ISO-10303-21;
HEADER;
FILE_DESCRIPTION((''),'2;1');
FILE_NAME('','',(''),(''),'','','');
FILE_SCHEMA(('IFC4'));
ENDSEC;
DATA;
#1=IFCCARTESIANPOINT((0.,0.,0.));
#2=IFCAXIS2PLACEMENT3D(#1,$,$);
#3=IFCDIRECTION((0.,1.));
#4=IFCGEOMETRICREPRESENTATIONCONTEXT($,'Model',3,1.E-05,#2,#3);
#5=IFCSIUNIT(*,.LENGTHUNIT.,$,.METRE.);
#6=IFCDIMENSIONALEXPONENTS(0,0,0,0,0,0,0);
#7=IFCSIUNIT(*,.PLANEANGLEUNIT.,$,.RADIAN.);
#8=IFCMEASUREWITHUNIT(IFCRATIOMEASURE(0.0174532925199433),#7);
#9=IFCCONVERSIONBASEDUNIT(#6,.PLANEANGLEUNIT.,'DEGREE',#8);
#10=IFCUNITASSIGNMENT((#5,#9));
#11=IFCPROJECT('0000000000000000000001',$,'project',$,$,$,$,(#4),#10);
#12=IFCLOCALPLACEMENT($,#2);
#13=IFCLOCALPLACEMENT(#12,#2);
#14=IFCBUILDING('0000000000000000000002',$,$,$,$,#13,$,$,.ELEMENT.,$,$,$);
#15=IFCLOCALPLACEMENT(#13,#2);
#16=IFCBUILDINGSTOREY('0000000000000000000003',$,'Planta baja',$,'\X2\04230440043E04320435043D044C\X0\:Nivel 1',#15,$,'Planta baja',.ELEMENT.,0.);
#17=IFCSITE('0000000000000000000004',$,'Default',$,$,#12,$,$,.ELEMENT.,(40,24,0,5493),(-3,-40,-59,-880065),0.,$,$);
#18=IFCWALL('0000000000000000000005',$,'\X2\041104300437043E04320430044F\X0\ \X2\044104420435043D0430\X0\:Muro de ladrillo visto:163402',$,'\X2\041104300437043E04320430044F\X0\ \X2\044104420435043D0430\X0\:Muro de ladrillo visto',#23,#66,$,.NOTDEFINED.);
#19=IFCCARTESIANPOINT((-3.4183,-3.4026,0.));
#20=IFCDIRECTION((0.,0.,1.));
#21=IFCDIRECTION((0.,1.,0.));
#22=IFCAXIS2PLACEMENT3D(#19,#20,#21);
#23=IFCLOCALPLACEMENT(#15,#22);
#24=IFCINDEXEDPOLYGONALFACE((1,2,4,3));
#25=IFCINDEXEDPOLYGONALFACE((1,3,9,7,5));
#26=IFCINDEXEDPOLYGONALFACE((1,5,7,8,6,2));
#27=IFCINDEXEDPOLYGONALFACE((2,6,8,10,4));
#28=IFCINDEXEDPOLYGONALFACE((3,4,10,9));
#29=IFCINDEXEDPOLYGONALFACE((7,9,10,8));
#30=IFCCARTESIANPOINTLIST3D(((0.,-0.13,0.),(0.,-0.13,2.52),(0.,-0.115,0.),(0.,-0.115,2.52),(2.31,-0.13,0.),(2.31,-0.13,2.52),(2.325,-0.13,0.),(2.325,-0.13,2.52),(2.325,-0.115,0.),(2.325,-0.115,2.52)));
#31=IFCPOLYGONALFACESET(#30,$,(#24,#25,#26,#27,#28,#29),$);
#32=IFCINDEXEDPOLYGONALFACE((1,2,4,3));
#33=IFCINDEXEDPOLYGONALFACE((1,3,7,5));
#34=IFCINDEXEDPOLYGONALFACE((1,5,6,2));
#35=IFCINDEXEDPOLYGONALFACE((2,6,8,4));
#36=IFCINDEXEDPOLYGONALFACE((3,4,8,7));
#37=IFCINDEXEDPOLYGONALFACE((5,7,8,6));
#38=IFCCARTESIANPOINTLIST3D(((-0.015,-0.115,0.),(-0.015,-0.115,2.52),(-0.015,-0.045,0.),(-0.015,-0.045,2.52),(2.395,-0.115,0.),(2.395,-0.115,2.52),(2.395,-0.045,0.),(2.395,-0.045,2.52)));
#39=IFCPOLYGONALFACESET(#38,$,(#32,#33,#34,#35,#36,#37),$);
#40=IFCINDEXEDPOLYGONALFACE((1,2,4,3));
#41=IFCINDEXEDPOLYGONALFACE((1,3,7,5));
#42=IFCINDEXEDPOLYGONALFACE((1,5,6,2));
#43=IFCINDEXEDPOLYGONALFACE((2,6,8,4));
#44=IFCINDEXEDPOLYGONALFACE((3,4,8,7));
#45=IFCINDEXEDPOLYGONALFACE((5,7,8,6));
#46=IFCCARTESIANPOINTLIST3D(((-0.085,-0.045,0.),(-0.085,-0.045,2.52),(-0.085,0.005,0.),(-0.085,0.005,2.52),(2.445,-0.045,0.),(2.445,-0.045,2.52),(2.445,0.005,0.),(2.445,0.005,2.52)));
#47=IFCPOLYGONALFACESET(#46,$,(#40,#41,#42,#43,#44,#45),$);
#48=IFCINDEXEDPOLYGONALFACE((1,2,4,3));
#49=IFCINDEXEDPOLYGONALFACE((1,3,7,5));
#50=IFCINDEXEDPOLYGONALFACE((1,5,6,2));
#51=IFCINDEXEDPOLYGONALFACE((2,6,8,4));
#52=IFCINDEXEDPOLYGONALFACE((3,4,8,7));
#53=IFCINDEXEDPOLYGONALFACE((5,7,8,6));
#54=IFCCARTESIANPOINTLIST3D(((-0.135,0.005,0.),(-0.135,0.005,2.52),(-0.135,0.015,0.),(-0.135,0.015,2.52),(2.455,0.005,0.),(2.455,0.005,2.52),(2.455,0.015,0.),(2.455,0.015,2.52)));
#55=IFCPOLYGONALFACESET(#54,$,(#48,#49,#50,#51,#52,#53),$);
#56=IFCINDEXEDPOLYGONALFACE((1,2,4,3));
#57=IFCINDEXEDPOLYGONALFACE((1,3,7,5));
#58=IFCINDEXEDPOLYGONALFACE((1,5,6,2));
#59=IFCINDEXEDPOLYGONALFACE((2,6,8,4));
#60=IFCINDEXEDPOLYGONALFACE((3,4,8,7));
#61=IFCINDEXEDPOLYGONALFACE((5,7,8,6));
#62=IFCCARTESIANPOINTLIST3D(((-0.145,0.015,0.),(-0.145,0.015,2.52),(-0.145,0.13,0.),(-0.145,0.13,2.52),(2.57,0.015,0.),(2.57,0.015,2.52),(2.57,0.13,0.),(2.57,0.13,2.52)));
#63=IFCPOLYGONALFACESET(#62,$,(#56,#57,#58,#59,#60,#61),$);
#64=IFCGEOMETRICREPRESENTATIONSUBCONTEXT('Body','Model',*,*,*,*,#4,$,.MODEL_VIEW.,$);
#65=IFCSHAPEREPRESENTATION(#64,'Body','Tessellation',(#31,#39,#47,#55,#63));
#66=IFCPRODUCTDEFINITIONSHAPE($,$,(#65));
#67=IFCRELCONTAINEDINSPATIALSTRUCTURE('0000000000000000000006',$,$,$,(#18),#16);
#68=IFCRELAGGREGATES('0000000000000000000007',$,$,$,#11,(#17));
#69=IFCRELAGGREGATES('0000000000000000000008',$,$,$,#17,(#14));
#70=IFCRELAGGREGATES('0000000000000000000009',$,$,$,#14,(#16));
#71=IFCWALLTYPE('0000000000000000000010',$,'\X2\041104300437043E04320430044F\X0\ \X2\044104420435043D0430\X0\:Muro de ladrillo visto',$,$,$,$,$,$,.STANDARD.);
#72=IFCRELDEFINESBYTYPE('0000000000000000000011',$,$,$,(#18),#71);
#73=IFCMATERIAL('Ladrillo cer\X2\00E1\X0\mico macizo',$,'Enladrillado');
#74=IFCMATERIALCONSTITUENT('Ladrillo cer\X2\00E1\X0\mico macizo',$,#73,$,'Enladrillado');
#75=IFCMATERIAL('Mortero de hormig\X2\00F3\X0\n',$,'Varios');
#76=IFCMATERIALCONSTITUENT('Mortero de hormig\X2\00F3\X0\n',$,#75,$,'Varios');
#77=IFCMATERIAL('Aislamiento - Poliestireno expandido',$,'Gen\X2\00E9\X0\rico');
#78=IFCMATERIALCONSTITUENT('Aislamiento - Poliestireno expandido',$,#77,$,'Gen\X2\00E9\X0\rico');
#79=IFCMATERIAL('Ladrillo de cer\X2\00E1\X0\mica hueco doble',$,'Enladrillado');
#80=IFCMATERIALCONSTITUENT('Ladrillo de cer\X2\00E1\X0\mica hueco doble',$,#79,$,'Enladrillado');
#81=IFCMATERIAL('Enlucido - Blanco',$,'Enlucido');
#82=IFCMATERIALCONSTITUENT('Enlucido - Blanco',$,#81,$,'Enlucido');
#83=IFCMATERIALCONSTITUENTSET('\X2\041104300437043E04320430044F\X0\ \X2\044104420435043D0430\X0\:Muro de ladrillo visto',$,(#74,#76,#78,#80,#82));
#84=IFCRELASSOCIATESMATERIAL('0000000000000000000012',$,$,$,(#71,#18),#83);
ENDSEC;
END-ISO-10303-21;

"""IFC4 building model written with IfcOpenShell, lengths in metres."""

from ifc_helpers import new_model, entity, si_unit, converted_unit, direction, frame, origin, place, context, subcontext, project, spatial, indexed_curve, outline, extrude, material, constituent, constituent_set, type_object, element, save


model = new_model("IFC4")

# Units and contexts
model_context = context("Model", 3, precision=1e-05, world=origin(), true_north=direction((0.0, 1.0)))
body_context = subcontext(model_context, "Body", "Model", "MODEL_VIEW")
ifc_project = project(units=[si_unit("LENGTHUNIT", "METRE"), converted_unit("PLANEANGLEUNIT", "DEGREE", entity("IfcRatioMeasure", 0.0174532925199433), si_unit("PLANEANGLEUNIT", "RADIAN"), dimensions=[0, 0, 0, 0, 0, 0, 0])], contexts=[model_context])

# Site, building, storey
site_placement = place(None, origin())
site = spatial("IfcSite", under=ifc_project, at=site_placement, Name="Default", CompositionType="ELEMENT", RefLatitude=(40, 24, 0, 5493), RefLongitude=(-3, -40, -59, -880065), RefElevation=0.0)
building_placement = place(site_placement, origin())
building = spatial("IfcBuilding", under=site, at=building_placement, CompositionType="ELEMENT")
storey_placement = place(building_placement, origin())
storey = spatial("IfcBuildingStorey", under=building, at=storey_placement, Name="Planta baja", ObjectType="Уровень:Nivel 1", LongName="Planta baja", CompositionType="ELEMENT", Elevation=0.0)

# Shared definitions
ifc_material_1 = material(Name="Enlucido - Blanco", Category="Enlucido")

# Shared definitions
ifc_material_2 = material(Name="Ladrillo cerámico macizo", Category="Enladrillado")
ifc_constituent_1 = constituent(ifc_material_2, Name="Ladrillo cerámico macizo", Category="Enladrillado")
ifc_material_3 = material(Name="Mortero de hormigón", Category="Varios")
ifc_constituent_2 = constituent(ifc_material_3, Name="Mortero de hormigón", Category="Varios")
ifc_material_4 = material(Name="Aislamiento - Poliestireno expandido", Category="Genérico")
ifc_constituent_3 = constituent(ifc_material_4, Name="Aislamiento - Poliestireno expandido", Category="Genérico")
ifc_material_5 = material(Name="Ladrillo de cerámica hueco doble", Category="Enladrillado")
ifc_constituent_4 = constituent(ifc_material_5, Name="Ladrillo de cerámica hueco doble", Category="Enladrillado")
ifc_constituent_5 = constituent(ifc_material_1, Name="Enlucido - Blanco", Category="Enlucido")
ifc_constituent_set_1 = constituent_set(constituents=[ifc_constituent_1, ifc_constituent_2, ifc_constituent_3, ifc_constituent_4, ifc_constituent_5], Name="Базовая стена:Muro de ladrillo visto")
wall_type_1 = type_object("IfcWallType", Name="Базовая стена:Muro de ladrillo visto", PredefinedType="STANDARD", material=ifc_constituent_set_1)

# Wall
wall_1_placement = place(storey_placement, frame((-3.4183, -3.4026, 0.0), z_axis=(0.0, 0.0, 1.0), x_axis=(0.0, 1.0, 0.0)))
element("IfcWall", 1, at=wall_1_placement, inside=storey, type_object=wall_type_1, material=ifc_constituent_set_1, Name="Базовая стена:Muro de ladrillo visto:163402", ObjectType="Базовая стена:Muro de ladrillo visto", PredefinedType="NOTDEFINED", context=body_context, shape_type="SweptSolid", body=[
    extrude(outline(indexed_curve([(0.918, -0.006), (0.933, -0.006), (0.933, 0.009), (-1.392, 0.009), (-1.392, -0.006), (0.918, -0.006)], self_intersect=False)), frame((1.392, -0.124, 0.0)), (0.0, 0.0, 1.0), 2.52),
    extrude(outline(indexed_curve([(-1.205, -0.035), (1.205, -0.035), (1.205, 0.035), (-1.205, 0.035), (-1.205, -0.035)], self_intersect=False)), frame((1.19, -0.08, 0.0)), (0.0, 0.0, 1.0), 2.52),
    extrude(outline(indexed_curve([(-1.265, -0.025), (1.265, -0.025), (1.265, 0.025), (-1.265, 0.025), (-1.265, -0.025)], self_intersect=False)), frame((1.18, -0.02, 0.0)), (0.0, 0.0, 1.0), 2.52),
    extrude(outline(indexed_curve([(-1.295, -0.005), (1.295, -0.005), (1.295, 0.005), (-1.295, 0.005), (-1.295, -0.005)], self_intersect=False)), frame((1.16, 0.01, 0.0)), (0.0, 0.0, 1.0), 2.52),
    extrude(outline(indexed_curve([(-0.0575, -1.3575), (0.0575, -1.3575), (0.0575, 1.3575), (-0.0575, 1.3575), (-0.0575, -1.3575)], self_intersect=False)), frame((1.2125, 0.0725, 0.0), z_axis=(0.0, 0.0, 1.0), x_axis=(0.0, -1.0, 0.0)), (0.0, 0.0, 1.0), 2.52),
])

save(model, "model.ifc")
